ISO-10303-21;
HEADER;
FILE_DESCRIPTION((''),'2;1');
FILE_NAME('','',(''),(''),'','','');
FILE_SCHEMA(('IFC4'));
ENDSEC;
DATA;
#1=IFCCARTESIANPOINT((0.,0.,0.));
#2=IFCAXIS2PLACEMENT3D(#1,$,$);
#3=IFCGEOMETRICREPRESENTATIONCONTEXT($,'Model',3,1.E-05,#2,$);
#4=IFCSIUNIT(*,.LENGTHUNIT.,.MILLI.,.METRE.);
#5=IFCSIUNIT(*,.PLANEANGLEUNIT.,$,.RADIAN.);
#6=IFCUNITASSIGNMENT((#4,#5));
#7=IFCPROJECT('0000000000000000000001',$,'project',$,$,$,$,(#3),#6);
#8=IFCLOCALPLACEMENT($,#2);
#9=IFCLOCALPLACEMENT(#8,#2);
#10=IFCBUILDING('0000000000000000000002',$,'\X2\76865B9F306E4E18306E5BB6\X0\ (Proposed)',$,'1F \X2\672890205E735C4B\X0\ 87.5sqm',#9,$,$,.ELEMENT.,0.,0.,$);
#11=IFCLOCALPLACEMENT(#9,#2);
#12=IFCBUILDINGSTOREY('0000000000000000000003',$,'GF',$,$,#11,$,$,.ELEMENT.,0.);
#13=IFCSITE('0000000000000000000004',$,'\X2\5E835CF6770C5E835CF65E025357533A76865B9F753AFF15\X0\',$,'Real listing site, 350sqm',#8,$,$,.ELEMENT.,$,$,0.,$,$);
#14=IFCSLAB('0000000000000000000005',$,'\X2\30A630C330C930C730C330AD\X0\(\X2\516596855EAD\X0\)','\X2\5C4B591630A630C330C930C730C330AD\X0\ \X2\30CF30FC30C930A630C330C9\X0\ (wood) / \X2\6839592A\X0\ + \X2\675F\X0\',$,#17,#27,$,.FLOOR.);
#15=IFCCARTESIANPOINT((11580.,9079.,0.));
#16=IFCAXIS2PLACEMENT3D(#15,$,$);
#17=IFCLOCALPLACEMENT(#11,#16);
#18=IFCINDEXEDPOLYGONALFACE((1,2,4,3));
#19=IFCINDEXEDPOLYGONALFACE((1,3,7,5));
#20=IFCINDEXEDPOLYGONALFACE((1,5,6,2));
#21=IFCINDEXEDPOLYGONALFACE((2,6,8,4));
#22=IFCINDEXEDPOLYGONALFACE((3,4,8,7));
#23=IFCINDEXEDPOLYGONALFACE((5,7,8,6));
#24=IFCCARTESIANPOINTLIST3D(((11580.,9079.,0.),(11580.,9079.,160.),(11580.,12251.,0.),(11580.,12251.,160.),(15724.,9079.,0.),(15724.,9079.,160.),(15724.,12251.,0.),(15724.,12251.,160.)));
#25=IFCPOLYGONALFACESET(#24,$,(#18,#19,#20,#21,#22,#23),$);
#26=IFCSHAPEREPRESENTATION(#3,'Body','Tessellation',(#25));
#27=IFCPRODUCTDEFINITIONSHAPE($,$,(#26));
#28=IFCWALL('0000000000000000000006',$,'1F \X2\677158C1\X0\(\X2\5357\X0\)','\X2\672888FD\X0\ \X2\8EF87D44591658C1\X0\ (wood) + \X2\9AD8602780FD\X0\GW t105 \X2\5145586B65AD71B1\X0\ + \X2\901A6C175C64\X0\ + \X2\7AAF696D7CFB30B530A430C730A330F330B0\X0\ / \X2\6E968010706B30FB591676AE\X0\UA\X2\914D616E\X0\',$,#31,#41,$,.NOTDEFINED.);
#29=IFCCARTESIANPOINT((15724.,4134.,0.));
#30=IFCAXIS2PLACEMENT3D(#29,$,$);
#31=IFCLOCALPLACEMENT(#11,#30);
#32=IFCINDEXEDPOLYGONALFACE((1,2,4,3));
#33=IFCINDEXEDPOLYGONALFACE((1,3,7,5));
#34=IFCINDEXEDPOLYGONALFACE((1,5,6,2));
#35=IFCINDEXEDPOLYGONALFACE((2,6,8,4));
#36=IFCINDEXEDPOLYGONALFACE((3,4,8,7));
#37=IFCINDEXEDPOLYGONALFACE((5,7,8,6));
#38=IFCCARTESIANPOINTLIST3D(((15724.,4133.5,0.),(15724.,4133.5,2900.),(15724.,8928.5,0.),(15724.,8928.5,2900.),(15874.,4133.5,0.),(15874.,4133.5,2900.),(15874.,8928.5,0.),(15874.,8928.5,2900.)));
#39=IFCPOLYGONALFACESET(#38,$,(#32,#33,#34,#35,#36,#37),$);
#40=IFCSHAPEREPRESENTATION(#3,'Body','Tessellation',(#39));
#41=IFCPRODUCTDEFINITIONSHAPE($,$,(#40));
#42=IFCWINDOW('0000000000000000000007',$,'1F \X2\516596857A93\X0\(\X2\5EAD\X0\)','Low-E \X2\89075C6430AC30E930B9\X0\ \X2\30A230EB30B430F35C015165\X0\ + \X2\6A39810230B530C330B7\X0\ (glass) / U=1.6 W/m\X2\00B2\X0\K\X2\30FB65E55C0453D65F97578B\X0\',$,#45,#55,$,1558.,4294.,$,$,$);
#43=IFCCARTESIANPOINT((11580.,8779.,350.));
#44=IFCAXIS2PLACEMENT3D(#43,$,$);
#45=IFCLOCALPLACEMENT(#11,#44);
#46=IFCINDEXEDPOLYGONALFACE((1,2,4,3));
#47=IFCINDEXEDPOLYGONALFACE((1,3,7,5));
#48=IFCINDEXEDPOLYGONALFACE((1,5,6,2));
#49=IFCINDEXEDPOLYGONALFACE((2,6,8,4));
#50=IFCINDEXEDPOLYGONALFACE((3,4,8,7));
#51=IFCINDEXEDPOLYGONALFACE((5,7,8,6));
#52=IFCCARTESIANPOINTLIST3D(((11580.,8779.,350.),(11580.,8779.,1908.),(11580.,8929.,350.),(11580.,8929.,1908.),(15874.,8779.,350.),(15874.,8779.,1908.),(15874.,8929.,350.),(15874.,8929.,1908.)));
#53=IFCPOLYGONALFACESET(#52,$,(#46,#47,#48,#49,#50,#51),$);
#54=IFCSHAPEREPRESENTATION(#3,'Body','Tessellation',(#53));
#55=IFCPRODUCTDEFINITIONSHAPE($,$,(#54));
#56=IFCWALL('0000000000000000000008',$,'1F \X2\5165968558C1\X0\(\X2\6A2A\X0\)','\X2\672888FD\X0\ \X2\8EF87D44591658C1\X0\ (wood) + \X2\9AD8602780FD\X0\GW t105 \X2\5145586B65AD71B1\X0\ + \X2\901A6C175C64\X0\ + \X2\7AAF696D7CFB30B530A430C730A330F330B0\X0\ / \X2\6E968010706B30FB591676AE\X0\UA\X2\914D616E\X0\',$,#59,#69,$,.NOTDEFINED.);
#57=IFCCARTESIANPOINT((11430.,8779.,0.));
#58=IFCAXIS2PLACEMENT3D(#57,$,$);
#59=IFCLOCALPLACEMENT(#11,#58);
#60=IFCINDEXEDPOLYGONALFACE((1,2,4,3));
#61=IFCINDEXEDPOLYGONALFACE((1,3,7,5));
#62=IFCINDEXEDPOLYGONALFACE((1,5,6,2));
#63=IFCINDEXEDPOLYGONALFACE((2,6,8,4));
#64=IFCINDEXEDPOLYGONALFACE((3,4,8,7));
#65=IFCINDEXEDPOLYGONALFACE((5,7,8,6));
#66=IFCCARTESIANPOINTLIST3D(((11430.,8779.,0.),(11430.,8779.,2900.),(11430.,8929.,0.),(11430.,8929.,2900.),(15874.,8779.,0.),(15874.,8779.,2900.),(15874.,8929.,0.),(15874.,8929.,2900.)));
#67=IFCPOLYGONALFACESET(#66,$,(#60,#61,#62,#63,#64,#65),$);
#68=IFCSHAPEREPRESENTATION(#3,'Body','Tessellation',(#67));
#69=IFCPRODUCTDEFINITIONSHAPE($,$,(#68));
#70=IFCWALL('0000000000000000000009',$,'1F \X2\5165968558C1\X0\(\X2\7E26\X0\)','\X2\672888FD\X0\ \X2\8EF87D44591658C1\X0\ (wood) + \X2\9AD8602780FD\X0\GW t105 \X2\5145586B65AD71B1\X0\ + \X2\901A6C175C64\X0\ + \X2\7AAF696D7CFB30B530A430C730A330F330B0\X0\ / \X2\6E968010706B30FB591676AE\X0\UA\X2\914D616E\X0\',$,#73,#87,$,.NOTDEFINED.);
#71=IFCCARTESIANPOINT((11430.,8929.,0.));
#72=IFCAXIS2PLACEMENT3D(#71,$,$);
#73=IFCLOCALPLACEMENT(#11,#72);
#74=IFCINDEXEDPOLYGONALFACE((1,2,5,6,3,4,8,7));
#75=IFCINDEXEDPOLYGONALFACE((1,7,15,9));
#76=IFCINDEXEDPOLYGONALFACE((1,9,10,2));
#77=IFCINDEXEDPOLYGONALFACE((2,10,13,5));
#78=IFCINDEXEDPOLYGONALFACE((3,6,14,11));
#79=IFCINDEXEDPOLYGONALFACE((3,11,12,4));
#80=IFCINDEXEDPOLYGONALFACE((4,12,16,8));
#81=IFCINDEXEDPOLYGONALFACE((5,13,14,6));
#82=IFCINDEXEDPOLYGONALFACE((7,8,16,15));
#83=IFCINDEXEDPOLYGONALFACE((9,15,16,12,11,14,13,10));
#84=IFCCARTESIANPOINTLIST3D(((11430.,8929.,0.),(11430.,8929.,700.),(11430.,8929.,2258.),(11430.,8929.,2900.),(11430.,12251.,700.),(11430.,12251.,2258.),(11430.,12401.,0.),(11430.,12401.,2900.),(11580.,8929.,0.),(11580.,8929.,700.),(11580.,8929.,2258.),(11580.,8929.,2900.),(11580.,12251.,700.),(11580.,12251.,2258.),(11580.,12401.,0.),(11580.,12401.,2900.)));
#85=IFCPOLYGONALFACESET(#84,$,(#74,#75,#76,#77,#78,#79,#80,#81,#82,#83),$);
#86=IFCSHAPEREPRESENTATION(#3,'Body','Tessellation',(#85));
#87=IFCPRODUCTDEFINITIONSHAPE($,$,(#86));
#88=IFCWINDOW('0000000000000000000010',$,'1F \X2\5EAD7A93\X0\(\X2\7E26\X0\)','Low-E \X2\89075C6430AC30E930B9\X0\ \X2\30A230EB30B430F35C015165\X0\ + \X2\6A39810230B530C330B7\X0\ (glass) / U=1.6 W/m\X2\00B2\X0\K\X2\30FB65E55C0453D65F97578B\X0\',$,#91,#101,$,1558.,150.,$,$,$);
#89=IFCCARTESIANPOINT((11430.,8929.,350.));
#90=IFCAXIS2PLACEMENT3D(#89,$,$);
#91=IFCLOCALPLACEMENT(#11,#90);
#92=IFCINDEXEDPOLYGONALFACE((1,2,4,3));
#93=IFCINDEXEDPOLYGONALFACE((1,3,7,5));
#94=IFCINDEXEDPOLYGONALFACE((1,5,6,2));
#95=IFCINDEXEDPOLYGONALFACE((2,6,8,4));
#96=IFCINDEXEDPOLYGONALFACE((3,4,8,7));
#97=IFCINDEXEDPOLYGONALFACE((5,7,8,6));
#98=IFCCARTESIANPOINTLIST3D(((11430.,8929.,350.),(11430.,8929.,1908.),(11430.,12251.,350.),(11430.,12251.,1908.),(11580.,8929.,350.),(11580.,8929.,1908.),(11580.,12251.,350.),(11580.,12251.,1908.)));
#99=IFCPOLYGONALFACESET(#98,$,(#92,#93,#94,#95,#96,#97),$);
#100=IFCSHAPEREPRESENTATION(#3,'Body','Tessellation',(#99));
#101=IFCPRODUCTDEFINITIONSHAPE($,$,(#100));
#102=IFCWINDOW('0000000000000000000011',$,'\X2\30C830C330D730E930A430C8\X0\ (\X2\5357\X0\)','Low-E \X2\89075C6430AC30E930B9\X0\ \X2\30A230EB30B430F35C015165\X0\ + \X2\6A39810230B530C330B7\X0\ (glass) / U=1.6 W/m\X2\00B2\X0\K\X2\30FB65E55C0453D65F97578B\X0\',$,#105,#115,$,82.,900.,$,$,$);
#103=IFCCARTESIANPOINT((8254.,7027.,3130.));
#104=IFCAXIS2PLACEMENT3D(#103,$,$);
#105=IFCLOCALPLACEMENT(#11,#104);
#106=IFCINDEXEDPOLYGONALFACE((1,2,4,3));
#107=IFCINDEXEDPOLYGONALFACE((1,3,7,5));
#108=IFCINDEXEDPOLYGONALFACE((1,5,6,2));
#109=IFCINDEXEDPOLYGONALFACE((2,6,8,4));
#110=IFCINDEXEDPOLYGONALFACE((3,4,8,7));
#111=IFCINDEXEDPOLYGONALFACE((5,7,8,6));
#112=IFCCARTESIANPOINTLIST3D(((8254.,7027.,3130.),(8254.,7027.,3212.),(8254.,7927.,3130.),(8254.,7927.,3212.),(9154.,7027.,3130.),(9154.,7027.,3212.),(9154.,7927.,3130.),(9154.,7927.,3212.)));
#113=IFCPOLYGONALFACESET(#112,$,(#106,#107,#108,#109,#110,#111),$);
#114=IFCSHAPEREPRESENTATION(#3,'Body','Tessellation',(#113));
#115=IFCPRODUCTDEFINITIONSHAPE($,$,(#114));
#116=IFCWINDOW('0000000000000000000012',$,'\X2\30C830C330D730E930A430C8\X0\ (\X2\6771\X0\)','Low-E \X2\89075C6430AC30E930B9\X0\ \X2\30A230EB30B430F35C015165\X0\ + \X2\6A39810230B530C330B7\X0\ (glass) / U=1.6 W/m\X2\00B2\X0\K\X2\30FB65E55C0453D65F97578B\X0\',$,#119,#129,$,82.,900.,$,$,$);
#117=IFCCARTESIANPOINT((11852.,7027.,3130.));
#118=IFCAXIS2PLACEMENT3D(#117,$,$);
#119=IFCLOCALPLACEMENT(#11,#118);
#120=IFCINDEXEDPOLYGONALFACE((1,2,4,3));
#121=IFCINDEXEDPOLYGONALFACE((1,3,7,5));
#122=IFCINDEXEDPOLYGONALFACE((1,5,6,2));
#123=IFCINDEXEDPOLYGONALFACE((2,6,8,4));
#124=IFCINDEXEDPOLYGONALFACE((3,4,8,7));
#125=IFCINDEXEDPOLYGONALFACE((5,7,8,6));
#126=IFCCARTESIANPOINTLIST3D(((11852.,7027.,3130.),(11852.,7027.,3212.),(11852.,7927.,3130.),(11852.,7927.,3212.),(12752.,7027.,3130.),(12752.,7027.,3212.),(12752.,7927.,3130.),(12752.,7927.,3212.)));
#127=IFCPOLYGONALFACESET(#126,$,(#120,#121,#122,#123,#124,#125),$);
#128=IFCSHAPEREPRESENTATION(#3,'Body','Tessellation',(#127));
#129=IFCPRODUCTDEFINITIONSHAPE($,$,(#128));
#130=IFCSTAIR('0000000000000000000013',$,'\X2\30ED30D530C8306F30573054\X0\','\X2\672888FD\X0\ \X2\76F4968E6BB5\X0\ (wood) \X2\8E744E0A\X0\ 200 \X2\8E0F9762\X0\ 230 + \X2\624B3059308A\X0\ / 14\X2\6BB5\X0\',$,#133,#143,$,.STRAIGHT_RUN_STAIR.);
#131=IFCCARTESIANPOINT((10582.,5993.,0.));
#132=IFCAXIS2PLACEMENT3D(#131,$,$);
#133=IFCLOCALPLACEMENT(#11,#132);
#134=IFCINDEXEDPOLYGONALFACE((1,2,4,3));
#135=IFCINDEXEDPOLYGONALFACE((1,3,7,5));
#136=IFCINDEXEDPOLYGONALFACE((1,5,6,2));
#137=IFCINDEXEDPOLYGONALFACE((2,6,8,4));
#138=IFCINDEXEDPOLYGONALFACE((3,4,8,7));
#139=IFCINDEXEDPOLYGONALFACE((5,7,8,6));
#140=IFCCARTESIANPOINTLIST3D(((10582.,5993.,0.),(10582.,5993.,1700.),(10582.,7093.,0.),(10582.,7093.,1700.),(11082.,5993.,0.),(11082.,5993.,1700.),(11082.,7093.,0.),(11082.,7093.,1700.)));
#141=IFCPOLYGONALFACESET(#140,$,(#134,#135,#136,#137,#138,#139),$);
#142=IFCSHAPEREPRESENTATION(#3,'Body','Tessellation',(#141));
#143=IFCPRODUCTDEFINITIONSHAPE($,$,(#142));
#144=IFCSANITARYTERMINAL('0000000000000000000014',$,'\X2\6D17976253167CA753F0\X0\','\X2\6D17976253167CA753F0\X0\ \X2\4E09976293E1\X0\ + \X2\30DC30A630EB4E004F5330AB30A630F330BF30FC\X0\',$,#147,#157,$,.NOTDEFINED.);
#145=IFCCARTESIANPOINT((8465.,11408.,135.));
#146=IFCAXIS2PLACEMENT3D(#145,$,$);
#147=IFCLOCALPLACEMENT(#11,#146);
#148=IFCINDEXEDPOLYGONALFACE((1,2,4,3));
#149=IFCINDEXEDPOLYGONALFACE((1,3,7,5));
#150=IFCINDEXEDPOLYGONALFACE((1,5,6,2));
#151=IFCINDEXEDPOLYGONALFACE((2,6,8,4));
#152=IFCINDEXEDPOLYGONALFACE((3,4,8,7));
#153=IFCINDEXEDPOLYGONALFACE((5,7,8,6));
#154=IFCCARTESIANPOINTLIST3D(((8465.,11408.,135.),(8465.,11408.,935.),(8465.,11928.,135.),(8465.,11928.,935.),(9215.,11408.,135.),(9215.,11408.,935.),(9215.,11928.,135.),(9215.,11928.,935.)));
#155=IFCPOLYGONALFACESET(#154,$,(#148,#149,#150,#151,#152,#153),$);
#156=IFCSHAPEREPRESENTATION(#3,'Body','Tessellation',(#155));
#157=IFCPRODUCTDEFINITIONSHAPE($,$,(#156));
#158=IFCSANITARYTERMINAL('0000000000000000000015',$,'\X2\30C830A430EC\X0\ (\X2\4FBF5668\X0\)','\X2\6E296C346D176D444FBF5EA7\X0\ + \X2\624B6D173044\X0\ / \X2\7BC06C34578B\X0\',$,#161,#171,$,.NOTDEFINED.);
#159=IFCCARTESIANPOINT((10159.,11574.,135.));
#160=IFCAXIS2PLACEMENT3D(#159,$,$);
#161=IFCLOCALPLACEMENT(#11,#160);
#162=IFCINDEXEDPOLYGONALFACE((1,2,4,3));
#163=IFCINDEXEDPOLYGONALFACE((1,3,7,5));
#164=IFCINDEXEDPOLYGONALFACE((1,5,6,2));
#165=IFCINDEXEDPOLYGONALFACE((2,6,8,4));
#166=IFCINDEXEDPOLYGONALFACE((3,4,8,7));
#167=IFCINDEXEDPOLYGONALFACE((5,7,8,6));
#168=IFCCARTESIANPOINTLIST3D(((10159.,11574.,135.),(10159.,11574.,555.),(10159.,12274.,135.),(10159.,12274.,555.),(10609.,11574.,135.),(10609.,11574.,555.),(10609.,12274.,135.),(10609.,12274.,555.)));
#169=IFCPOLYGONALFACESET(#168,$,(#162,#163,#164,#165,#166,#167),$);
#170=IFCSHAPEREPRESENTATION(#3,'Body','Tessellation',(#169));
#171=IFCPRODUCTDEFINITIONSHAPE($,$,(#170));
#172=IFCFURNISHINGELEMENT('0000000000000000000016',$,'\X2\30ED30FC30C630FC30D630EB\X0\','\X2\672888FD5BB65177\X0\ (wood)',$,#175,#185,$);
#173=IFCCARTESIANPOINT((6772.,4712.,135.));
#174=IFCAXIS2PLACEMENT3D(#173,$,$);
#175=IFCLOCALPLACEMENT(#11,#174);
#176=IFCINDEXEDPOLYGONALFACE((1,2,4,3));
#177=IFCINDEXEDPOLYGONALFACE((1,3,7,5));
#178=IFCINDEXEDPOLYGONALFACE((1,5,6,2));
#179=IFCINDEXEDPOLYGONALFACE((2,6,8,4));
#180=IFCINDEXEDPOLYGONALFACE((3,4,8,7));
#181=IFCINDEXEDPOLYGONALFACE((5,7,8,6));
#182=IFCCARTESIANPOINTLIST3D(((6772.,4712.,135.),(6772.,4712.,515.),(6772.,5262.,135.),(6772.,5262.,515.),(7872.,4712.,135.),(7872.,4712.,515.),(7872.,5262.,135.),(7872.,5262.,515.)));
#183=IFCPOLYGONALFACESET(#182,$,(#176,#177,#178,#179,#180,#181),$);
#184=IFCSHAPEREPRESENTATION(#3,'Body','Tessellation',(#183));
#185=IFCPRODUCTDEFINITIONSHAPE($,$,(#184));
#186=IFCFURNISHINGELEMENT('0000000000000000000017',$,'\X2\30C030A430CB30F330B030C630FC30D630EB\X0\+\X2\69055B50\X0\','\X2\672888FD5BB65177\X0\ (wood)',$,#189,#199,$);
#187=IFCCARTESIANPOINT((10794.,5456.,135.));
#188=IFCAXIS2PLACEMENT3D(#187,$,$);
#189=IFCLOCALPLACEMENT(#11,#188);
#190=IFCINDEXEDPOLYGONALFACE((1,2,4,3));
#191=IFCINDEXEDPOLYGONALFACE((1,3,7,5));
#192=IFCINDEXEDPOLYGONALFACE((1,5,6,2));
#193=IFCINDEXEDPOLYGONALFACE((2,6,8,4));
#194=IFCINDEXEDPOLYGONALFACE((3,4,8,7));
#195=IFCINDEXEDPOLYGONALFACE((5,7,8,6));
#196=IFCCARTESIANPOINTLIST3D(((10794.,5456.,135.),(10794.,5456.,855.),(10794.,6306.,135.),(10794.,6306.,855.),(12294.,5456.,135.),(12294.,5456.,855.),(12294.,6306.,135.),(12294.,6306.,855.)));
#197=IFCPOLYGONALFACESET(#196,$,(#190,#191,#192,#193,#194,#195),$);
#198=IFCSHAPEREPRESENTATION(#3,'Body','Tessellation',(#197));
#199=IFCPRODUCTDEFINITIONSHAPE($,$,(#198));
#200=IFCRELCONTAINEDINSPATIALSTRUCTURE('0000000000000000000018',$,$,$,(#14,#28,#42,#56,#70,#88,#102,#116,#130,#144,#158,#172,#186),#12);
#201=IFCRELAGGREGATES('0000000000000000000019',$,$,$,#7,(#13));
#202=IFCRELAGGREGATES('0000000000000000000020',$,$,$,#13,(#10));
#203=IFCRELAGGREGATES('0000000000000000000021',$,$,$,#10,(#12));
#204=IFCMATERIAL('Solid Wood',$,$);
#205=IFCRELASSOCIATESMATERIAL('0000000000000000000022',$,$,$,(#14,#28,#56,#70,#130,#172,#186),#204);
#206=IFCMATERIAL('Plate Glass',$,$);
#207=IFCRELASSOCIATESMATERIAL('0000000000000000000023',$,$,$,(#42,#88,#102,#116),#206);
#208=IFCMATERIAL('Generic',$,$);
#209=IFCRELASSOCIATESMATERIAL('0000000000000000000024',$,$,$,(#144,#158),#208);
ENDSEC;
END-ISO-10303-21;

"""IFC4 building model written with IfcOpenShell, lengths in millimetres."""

from ifc_helpers import new_model, si_unit, frame, frame_2d, origin, place, context, project, spatial, rectangle, extrude, material, element, fill, save


model = new_model("IFC4")

# Units and contexts
model_context = context("Model", 3, precision=1e-05, world=origin())
ifc_project = project(units=[si_unit("LENGTHUNIT", "METRE", prefix="MILLI"), si_unit("PLANEANGLEUNIT", "RADIAN")], contexts=[model_context])

# Site, building, storey
site_placement = place(None, origin())
site = spatial("IfcSite", under=ifc_project, at=site_placement, Name="広島県広島市南区皆実町５", ObjectType="Real listing site, 350sqm", CompositionType="ELEMENT", RefElevation=0.0)
building_placement = place(site_placement, origin())
building = spatial("IfcBuilding", under=site, at=building_placement, Name="皆実の丘の家 (Proposed)", ObjectType="1F 木造平屋 87.5sqm", CompositionType="ELEMENT", ElevationOfRefHeight=0.0, ElevationOfTerrain=0.0)
storey_placement = place(building_placement, origin())
storey = spatial("IfcBuildingStorey", under=building, at=storey_placement, Name="GF", CompositionType="ELEMENT", Elevation=0.0)

# Slab
ifc_material_1 = material(Name="Solid Wood")
slab_placement = place(storey_placement, frame((11580.0, 9079.0, 0.0)))
element("IfcSlab", 1, at=slab_placement, inside=storey, material=ifc_material_1, Name="ウッドデッキ(入隅庭)", Description="屋外ウッドデッキ ハードウッド (wood) / 根太 + 束", PredefinedType="FLOOR", context=model_context, shape_type="SweptSolid", body=[
    extrude(rectangle(XDim=4144.0, YDim=3172.0, at=frame_2d((2072.0, 1586.0))), frame((11580.0, 9079.0, 0.0)), (0.0, 0.0, 1.0), 160.0),
])

# Wall, opening, window
wall_1_placement = place(storey_placement, frame((15724.0, 4134.0, 0.0)))
wall_1 = element("IfcWall", 2, at=wall_1_placement, inside=storey, material=ifc_material_1, Name="1F 東壁(南)", Description="木製 軸組外壁 (wood) + 高性能GW t105 充填断熱 + 通気層 + 窯業系サイディング / 準耐火・外皮UA配慮", PredefinedType="NOTDEFINED", context=model_context, shape_type="SweptSolid", body=[
    extrude(rectangle(XDim=150.0, YDim=4795.0, at=frame_2d((75.0, 2397.0))), frame((15724.0, 4134.0, 0.0)), (0.0, 0.0, 1.0), 2900.0),
])
opening_1_placement = place(storey_placement, frame((11580.0, 8779.0, 350.0)))
opening_1 = element("IfcOpeningElement", 3, at=opening_1_placement, cuts=wall_1, PredefinedType="NOTDEFINED", context=model_context, shape_type="SweptSolid", body=[
    extrude(rectangle(XDim=4294.0, YDim=150.0, at=frame_2d((2147.0, 75.0))), frame((11580.0, 8779.0, 350.0)), (0.0, 0.0, 1.0), 1558.0),
])
ifc_material_2 = material(Name="Plate Glass")
window_1_placement = place(storey_placement, frame((11580.0, 8779.0, 350.0)))
window_1 = element("IfcWindow", 4, at=window_1_placement, inside=storey, material=ifc_material_2, Name="1F 入隅窓(庭)", Description="Low-E 複層ガラス アルゴン封入 + 樹脂サッシ (glass) / U=1.6 W/m²K・日射取得型", OverallHeight=1558.0, OverallWidth=4294.0, context=model_context, shape_type="SweptSolid", body=[
    extrude(rectangle(XDim=4294.0, YDim=150.0, at=frame_2d((2147.0, 75.0))), frame((11580.0, 8779.0, 350.0)), (0.0, 0.0, 1.0), 1558.0),
])
fill(opening_1, window_1)

# Wall
wall_2_placement = place(storey_placement, frame((11430.0, 8779.0, 0.0)))
element("IfcWall", 5, at=wall_2_placement, inside=storey, material=ifc_material_1, Name="1F 入隅壁(横)", Description="木製 軸組外壁 (wood) + 高性能GW t105 充填断熱 + 通気層 + 窯業系サイディング / 準耐火・外皮UA配慮", PredefinedType="NOTDEFINED", context=model_context, shape_type="SweptSolid", body=[
    extrude(rectangle(XDim=4444.0, YDim=150.0, at=frame_2d((2222.0, 75.0))), frame((11430.0, 8779.0, 0.0)), (0.0, 0.0, 1.0), 2900.0),
])

# Wall, opening, window
wall_3_placement = place(storey_placement, frame((11430.0, 8929.0, 0.0)))
wall_3 = element("IfcWall", 6, at=wall_3_placement, inside=storey, material=ifc_material_1, Name="1F 入隅壁(縦)", Description="木製 軸組外壁 (wood) + 高性能GW t105 充填断熱 + 通気層 + 窯業系サイディング / 準耐火・外皮UA配慮", PredefinedType="NOTDEFINED", context=model_context, shape_type="SweptSolid", body=[
    extrude(rectangle(XDim=150.0, YDim=3472.0, at=frame_2d((75.0, 1736.0))), frame((11430.0, 8929.0, 0.0)), (0.0, 0.0, 1.0), 2900.0),
])
opening_2_placement = place(storey_placement, frame((11430.0, 8929.0, 350.0)))
opening_2 = element("IfcOpeningElement", 7, at=opening_2_placement, cuts=wall_3, PredefinedType="NOTDEFINED", context=model_context, shape_type="SweptSolid", body=[
    extrude(rectangle(XDim=150.0, YDim=3322.0, at=frame_2d((75.0, 1661.0))), frame((11430.0, 8929.0, 350.0)), (0.0, 0.0, 1.0), 1558.0),
])
window_2_placement = place(storey_placement, frame((11430.0, 8929.0, 350.0)))
window_2 = element("IfcWindow", 8, at=window_2_placement, inside=storey, material=ifc_material_2, Name="1F 庭窓(縦)", Description="Low-E 複層ガラス アルゴン封入 + 樹脂サッシ (glass) / U=1.6 W/m²K・日射取得型", OverallHeight=1558.0, OverallWidth=150.0, context=model_context, shape_type="SweptSolid", body=[
    extrude(rectangle(XDim=150.0, YDim=3322.0, at=frame_2d((75.0, 1661.0))), frame((11430.0, 8929.0, 350.0)), (0.0, 0.0, 1.0), 1558.0),
])
fill(opening_2, window_2)

# Windows
window_3_placement = place(storey_placement, frame((8254.0, 7027.0, 3130.0)))
element("IfcWindow", 9, at=window_3_placement, inside=storey, material=ifc_material_2, Name="トップライト (南)", Description="Low-E 複層ガラス アルゴン封入 + 樹脂サッシ (glass) / U=1.6 W/m²K・日射取得型", OverallHeight=82.0, OverallWidth=900.0, context=model_context, shape_type="SweptSolid", body=[
    extrude(rectangle(XDim=900.0, YDim=900.0, at=frame_2d((450.0, 450.0))), frame((8254.0, 7027.0, 3130.0)), (0.0, 0.0, 1.0), 82.0),
])
window_4_placement = place(storey_placement, frame((11852.0, 7027.0, 3130.0)))
element("IfcWindow", 10, at=window_4_placement, inside=storey, material=ifc_material_2, Name="トップライト (東)", Description="Low-E 複層ガラス アルゴン封入 + 樹脂サッシ (glass) / U=1.6 W/m²K・日射取得型", OverallHeight=82.0, OverallWidth=900.0, context=model_context, shape_type="SweptSolid", body=[
    extrude(rectangle(XDim=900.0, YDim=900.0, at=frame_2d((450.0, 450.0))), frame((11852.0, 7027.0, 3130.0)), (0.0, 0.0, 1.0), 82.0),
])

# Stair
stair_placement = place(storey_placement, frame((10582.0, 5993.0, 0.0)))
element("IfcStair", 11, at=stair_placement, inside=storey, material=ifc_material_1, Name="ロフトはしご", Description="木製 直階段 (wood) 蹴上 200 踏面 230 + 手すり / 14段", PredefinedType="STRAIGHT_RUN_STAIR", context=model_context, shape_type="SweptSolid", body=[
    extrude(rectangle(XDim=500.0, YDim=1100.0, at=frame_2d((250.0, 550.0))), frame((10582.0, 5993.0, 0.0)), (0.0, 0.0, 1.0), 1700.0),
])

# Sanitary terminals
ifc_material_3 = material(Name="Generic")
sanitary_terminal_1_placement = place(storey_placement, frame((8465.0, 11408.0, 135.0)))
element("IfcSanitaryTerminal", 12, at=sanitary_terminal_1_placement, inside=storey, material=ifc_material_3, Name="洗面化粧台", Description="洗面化粧台 三面鏡 + ボウル一体カウンター", PredefinedType="NOTDEFINED", context=model_context, shape_type="SweptSolid", body=[
    extrude(rectangle(XDim=750.0, YDim=520.0, at=frame_2d((375.0, 260.0))), frame((8465.0, 11408.0, 135.0)), (0.0, 0.0, 1.0), 800.0),
])
sanitary_terminal_2_placement = place(storey_placement, frame((10159.0, 11574.0, 135.0)))
element("IfcSanitaryTerminal", 13, at=sanitary_terminal_2_placement, inside=storey, material=ifc_material_3, Name="トイレ (便器)", Description="温水洗浄便座 + 手洗い / 節水型", PredefinedType="NOTDEFINED", context=model_context, shape_type="SweptSolid", body=[
    extrude(rectangle(XDim=450.0, YDim=700.0, at=frame_2d((225.0, 350.0))), frame((10159.0, 11574.0, 135.0)), (0.0, 0.0, 1.0), 420.0),
])

# Furnishing elements
furnishing_1_placement = place(storey_placement, frame((6772.0, 4712.0, 135.0)))
element("IfcFurnishingElement", 14, at=furnishing_1_placement, inside=storey, material=ifc_material_1, Name="ローテーブル", Description="木製家具 (wood)", context=model_context, shape_type="SweptSolid", body=[
    extrude(rectangle(XDim=1100.0, YDim=550.0, at=frame_2d((550.0, 275.0))), frame((6772.0, 4712.0, 135.0)), (0.0, 0.0, 1.0), 380.0),
])
furnishing_2_placement = place(storey_placement, frame((10794.0, 5456.0, 135.0)))
element("IfcFurnishingElement", 15, at=furnishing_2_placement, inside=storey, material=ifc_material_1, Name="ダイニングテーブル+椅子", Description="木製家具 (wood)", context=model_context, shape_type="SweptSolid", body=[
    extrude(rectangle(XDim=1500.0, YDim=850.0, at=frame_2d((750.0, 425.0))), frame((10794.0, 5456.0, 135.0)), (0.0, 0.0, 1.0), 720.0),
])

save(model, "model.ifc")
